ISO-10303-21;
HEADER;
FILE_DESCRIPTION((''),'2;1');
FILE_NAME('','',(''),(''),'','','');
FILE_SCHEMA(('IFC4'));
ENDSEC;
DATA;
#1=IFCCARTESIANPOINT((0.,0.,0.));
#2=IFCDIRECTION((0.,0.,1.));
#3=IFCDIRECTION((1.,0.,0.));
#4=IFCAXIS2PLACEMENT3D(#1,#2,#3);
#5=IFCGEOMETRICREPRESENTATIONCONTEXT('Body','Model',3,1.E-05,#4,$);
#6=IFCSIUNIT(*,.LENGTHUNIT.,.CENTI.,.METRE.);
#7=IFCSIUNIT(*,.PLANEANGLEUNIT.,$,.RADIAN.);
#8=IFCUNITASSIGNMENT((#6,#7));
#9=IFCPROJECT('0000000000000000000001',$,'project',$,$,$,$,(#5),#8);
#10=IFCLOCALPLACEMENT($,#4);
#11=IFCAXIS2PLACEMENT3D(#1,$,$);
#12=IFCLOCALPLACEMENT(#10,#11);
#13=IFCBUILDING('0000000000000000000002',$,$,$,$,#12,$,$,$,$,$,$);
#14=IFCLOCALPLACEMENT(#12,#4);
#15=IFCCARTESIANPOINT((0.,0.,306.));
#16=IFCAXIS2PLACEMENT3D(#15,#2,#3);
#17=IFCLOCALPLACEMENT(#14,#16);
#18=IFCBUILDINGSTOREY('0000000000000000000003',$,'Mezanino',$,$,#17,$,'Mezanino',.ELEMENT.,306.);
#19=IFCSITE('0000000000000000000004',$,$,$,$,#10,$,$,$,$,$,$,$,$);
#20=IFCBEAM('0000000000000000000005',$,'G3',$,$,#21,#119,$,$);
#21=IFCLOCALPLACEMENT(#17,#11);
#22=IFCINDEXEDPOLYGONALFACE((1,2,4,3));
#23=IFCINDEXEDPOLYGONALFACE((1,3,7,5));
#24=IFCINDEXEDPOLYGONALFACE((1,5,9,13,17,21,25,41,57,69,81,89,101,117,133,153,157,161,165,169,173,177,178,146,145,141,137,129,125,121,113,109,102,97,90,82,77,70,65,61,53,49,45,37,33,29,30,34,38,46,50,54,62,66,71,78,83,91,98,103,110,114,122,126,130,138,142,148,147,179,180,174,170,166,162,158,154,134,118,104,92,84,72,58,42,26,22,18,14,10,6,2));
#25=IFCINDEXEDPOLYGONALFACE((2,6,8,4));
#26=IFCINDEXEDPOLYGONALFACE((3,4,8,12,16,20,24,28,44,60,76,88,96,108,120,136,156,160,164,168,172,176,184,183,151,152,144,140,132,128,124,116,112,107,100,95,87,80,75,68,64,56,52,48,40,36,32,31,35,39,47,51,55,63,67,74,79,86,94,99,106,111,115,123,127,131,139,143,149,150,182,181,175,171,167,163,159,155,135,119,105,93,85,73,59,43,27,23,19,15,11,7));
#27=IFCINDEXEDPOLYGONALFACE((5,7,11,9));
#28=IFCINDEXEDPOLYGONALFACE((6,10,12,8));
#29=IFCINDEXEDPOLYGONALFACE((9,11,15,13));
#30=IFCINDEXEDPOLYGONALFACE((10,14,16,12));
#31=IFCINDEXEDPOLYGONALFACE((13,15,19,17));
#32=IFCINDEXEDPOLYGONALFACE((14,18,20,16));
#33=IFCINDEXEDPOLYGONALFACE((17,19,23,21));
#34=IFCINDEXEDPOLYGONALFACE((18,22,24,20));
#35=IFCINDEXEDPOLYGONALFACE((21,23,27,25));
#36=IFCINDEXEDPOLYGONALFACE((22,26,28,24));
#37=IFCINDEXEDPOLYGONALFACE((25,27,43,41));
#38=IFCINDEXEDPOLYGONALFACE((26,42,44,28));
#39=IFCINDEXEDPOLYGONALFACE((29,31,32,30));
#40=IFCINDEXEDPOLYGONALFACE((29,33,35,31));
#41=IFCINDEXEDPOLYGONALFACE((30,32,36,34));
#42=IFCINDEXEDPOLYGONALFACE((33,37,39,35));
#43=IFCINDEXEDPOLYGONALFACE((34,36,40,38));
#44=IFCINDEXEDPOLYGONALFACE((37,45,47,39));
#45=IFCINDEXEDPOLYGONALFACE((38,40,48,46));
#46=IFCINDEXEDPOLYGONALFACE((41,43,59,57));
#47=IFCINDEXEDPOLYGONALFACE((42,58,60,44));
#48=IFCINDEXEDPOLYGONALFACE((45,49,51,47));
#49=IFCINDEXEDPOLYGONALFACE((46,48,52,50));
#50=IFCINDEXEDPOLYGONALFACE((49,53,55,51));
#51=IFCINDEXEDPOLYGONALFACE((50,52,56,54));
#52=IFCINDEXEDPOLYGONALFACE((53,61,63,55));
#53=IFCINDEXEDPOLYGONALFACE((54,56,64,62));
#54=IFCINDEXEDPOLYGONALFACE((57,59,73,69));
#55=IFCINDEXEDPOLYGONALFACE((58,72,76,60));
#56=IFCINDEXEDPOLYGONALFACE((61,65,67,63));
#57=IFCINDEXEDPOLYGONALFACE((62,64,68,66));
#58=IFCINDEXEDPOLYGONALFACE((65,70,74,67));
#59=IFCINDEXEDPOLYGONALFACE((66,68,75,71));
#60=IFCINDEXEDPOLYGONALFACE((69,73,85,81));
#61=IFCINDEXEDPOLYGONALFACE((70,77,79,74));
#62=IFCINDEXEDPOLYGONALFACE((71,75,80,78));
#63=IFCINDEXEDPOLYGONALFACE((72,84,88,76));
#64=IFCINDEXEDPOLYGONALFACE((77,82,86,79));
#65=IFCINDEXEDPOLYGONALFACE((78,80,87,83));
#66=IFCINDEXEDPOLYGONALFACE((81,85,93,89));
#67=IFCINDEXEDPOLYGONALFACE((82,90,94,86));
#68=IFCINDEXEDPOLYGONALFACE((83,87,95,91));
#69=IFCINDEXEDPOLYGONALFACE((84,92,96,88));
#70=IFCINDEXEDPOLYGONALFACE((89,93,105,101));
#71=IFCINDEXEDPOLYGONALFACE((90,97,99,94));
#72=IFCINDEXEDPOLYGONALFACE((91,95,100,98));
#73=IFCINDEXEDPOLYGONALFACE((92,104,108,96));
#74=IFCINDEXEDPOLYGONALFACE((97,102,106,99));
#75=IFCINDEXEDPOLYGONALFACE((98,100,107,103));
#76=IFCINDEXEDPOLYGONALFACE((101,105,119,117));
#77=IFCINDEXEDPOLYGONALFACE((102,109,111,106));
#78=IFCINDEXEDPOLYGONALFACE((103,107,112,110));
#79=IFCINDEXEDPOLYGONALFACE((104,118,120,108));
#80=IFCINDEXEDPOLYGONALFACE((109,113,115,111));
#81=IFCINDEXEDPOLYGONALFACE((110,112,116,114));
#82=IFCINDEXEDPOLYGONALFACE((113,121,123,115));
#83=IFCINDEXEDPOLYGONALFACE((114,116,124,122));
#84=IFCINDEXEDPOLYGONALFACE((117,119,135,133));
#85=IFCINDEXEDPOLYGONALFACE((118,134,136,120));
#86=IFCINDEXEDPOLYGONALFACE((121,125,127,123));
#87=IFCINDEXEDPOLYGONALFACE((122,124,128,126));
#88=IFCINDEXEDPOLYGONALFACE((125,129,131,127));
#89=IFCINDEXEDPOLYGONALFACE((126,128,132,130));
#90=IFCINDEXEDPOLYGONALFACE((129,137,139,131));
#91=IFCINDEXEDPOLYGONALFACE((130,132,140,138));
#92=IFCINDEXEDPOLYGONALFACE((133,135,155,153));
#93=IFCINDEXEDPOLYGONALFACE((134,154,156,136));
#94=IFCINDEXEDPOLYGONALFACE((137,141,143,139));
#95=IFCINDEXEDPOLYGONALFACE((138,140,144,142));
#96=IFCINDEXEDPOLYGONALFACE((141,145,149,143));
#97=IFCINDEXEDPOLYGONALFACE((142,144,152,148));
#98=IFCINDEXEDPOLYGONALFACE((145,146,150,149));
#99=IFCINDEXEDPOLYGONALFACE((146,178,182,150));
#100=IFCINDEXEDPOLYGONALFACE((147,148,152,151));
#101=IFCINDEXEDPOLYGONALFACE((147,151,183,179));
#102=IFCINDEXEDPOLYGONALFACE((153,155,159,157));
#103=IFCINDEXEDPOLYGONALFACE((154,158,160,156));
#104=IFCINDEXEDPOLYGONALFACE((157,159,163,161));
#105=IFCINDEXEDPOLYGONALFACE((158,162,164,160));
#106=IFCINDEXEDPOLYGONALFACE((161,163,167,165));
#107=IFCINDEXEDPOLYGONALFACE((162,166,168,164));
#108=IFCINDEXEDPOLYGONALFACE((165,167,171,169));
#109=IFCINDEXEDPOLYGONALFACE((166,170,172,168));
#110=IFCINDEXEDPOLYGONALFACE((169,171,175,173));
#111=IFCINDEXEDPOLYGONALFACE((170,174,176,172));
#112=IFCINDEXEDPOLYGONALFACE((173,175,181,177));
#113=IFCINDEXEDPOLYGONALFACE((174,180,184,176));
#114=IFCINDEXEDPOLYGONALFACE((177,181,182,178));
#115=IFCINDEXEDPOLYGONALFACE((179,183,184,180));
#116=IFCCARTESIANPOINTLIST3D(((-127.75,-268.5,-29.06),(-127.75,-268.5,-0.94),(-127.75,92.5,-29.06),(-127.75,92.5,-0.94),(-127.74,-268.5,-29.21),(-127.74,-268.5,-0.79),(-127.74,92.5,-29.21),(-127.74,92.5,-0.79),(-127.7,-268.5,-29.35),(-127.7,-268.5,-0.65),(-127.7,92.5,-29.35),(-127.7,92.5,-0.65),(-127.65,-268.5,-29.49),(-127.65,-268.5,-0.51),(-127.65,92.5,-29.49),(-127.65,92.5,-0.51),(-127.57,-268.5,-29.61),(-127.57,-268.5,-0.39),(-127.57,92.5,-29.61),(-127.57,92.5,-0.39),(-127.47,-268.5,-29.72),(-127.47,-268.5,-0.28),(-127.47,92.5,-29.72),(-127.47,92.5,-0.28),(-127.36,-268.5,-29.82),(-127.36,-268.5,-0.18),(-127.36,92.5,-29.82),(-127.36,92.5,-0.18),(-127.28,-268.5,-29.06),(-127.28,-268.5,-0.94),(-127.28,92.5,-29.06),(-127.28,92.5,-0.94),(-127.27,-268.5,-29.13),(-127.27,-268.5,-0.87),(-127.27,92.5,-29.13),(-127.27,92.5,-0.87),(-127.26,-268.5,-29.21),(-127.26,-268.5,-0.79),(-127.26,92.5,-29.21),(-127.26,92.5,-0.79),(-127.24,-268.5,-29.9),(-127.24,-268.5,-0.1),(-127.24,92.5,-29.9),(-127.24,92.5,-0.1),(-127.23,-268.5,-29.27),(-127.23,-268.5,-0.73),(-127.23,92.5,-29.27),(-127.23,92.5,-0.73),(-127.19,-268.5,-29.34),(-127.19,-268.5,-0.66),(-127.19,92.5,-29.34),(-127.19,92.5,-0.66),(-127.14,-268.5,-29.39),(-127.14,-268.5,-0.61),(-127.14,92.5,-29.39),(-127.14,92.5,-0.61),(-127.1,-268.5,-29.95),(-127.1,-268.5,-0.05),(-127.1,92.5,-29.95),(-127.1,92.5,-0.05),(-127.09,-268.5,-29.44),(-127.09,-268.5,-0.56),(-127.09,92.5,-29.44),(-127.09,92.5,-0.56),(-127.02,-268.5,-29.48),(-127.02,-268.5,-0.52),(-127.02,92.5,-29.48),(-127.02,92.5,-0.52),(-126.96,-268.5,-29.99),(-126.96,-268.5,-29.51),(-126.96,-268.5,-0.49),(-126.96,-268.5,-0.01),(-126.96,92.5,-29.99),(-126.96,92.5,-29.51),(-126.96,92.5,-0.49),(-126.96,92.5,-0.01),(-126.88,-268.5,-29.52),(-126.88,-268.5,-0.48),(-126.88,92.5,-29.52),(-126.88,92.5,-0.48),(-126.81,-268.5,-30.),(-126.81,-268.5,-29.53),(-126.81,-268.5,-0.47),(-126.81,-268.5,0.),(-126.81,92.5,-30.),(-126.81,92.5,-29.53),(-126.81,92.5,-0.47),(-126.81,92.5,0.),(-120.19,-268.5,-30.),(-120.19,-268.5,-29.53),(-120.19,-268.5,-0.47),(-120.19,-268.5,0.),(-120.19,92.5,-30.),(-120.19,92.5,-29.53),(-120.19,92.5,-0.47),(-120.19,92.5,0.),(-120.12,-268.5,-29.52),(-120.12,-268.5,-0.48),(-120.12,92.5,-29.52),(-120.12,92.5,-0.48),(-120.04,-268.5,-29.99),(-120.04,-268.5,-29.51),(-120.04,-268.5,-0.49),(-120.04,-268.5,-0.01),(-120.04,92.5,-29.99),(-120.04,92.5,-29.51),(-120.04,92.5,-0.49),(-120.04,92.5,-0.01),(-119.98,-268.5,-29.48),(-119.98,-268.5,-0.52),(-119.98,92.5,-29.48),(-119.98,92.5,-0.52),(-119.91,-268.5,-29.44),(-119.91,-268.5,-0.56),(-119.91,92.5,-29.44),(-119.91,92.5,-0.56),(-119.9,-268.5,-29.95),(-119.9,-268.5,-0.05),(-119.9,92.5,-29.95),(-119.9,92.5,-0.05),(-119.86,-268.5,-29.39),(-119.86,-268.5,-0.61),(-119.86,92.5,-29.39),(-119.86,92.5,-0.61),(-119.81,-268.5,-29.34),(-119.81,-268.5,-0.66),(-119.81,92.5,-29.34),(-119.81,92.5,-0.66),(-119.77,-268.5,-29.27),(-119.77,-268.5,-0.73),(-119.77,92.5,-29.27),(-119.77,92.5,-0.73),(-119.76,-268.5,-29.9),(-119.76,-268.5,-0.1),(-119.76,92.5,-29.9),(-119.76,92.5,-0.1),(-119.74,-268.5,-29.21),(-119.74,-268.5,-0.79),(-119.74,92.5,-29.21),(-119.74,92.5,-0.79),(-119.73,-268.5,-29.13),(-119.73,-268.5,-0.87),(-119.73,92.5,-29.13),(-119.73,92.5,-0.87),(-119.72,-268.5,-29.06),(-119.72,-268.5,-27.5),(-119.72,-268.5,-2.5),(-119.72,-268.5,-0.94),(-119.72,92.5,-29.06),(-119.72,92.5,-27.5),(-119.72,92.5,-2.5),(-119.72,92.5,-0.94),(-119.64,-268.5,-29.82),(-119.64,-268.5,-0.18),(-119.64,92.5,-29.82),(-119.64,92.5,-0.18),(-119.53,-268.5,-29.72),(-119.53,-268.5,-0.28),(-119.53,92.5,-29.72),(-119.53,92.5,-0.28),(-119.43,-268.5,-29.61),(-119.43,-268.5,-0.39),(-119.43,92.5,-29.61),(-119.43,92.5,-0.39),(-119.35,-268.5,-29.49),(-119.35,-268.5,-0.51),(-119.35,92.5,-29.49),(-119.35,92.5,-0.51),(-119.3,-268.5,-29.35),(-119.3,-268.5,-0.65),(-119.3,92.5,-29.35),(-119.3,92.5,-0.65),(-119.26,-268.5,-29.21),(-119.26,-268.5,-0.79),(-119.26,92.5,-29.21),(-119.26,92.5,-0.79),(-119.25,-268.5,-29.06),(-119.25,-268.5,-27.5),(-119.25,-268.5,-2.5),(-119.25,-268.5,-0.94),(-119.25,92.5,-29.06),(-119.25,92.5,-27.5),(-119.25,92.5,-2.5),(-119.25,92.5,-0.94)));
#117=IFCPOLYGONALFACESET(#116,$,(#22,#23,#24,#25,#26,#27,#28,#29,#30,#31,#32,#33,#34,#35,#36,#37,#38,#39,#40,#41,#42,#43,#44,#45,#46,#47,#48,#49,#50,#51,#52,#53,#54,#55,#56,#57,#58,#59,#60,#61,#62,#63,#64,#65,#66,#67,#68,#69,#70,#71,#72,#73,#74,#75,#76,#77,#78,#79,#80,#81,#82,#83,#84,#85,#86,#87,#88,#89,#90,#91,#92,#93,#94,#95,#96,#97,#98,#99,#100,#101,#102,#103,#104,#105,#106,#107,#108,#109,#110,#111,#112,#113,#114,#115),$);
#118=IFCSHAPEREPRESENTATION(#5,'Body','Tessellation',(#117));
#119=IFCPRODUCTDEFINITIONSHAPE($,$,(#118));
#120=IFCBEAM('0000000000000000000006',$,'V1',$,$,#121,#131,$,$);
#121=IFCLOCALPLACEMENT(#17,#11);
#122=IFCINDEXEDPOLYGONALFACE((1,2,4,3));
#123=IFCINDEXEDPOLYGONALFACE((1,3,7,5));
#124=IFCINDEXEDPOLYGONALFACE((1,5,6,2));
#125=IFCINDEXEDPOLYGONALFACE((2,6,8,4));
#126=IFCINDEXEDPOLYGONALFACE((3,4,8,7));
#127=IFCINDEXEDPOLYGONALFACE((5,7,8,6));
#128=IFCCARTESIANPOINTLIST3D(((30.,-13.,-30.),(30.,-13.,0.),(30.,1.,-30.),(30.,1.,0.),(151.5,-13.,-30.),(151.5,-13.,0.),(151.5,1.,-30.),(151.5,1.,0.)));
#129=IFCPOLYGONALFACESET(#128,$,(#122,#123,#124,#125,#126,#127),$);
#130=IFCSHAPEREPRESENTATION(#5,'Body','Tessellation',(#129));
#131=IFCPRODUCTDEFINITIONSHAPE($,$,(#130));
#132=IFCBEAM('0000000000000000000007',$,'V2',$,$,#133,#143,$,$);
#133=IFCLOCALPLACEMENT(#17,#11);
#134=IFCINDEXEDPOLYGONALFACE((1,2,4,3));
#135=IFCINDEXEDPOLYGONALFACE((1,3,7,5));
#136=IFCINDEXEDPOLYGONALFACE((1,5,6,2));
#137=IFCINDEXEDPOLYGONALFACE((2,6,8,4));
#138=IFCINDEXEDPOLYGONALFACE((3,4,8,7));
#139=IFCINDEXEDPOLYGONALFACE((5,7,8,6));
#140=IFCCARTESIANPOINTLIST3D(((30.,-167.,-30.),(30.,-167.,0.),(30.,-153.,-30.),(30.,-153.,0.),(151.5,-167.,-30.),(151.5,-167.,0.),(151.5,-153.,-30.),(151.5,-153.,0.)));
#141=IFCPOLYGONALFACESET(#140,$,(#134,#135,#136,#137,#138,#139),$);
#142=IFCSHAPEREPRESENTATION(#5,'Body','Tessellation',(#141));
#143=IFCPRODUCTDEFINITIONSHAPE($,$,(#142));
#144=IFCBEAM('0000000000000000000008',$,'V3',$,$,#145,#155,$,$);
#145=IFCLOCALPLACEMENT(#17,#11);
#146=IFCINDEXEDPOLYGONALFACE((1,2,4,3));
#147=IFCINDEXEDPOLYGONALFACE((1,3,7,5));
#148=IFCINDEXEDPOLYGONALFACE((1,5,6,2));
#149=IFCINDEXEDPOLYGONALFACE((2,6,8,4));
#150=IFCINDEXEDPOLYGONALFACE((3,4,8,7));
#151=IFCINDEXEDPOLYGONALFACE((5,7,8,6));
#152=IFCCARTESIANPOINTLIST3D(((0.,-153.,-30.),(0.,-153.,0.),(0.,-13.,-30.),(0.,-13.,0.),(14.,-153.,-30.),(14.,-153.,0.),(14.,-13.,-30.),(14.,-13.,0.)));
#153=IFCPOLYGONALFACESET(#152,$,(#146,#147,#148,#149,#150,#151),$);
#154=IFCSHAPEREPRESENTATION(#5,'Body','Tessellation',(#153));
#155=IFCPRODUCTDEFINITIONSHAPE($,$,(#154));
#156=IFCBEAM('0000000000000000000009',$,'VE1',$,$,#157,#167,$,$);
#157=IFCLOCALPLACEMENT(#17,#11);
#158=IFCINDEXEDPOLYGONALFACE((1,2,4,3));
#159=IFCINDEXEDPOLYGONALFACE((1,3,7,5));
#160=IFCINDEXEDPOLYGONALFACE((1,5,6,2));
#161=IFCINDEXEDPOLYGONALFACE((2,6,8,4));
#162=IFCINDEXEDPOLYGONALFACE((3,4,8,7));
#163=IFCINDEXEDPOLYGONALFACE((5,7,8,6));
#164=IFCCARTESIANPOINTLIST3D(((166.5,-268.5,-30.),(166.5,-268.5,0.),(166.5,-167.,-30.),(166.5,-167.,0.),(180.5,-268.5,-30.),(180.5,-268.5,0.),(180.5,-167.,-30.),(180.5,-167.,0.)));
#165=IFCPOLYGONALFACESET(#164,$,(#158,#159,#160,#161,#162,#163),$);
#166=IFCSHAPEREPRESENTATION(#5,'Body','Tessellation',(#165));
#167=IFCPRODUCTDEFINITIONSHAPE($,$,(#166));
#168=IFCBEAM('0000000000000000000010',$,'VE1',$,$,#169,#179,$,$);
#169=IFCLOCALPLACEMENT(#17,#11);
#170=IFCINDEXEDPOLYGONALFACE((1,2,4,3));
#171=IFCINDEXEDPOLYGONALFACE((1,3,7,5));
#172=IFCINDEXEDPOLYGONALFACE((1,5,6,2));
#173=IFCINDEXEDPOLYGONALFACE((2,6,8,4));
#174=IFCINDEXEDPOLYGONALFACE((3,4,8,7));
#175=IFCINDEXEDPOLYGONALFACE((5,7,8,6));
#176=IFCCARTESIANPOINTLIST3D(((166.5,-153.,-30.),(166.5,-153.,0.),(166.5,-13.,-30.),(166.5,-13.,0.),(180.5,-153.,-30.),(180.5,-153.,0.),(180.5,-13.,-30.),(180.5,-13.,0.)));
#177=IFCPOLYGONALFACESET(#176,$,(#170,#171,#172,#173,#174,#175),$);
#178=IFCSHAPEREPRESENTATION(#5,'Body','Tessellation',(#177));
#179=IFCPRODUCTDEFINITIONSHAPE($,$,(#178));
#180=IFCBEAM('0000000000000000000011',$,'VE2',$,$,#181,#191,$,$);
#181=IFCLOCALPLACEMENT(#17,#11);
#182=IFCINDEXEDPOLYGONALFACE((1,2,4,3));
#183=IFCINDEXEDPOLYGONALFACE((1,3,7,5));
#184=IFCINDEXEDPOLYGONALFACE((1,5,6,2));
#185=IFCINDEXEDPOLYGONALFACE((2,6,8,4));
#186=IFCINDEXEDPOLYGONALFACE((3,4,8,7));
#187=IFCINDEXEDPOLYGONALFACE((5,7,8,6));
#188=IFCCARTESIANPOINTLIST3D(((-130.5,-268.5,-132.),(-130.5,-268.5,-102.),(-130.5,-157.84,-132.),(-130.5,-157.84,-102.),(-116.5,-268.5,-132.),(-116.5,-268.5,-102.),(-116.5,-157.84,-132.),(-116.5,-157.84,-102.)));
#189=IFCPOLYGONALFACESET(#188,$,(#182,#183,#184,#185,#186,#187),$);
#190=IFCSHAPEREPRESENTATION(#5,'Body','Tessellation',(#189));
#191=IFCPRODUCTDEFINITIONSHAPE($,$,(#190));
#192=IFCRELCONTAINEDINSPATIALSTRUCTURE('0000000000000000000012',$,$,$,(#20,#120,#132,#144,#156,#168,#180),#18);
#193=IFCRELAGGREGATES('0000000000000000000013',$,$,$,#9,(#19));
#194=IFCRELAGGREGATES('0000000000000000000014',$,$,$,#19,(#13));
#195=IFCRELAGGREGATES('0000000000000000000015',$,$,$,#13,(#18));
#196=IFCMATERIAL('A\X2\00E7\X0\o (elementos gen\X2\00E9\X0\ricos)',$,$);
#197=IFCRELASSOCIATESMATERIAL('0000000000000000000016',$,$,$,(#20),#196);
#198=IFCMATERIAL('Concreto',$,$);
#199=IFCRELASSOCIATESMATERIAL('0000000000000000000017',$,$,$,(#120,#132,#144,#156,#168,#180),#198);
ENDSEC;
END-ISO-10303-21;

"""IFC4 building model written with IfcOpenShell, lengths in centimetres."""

from ifc_helpers import new_model, si_unit, frame, origin, origin_with_axes, origin_2d_with_axis, place, context, project, spatial, polyline, rectangle, outline, extrude, material, element, save


model = new_model("IFC4")

# Units and contexts
model_context = context("Model", 3, precision=1e-05, world=origin_with_axes(), identifier="Body")
ifc_project = project(units=[si_unit("LENGTHUNIT", "METRE", prefix="CENTI"), si_unit("PLANEANGLEUNIT", "RADIAN")], contexts=[model_context])

# Site, building, storey
site_placement = place(None, origin_with_axes())
site = spatial("IfcSite", under=ifc_project, at=site_placement)
building_placement = place(site_placement, origin())
building = spatial("IfcBuilding", under=site, at=building_placement)
placement = place(building_placement, origin_with_axes())
storey_placement = place(placement, frame((0.0, 0.0, 306.0), z_axis=(0.0, 0.0, 1.0), x_axis=(1.0, 0.0, 0.0)))
storey = spatial("IfcBuildingStorey", under=building, at=storey_placement, Name="Mezanino", LongName="Mezanino", CompositionType="ELEMENT", Elevation=306.0)

# Shared definitions
ifc_material_1 = material(Name="Concreto")

# Beams
ifc_material_2 = material(Name="Aço (elementos genéricos)")
beam_1_placement = place(storey_placement, frame((-123.5, -88.0, 0.0), z_axis=(0.0, 0.0, 1.0), x_axis=(1.0, 0.0, 0.0)))
element("IfcBeam", 1, at=beam_1_placement, inside=storey, material=ifc_material_2, Name="G3", context=model_context, shape_type="SolidModel", body=[
    extrude(outline(polyline([(-4.25, -14.06), (-4.24, -14.21), (-4.2, -14.35), (-4.15, -14.49), (-4.07, -14.61), (-3.97, -14.72), (-3.86, -14.82), (-3.74, -14.9), (-3.6, -14.95), (-3.46, -14.99), (-3.31, -15.0), (3.31, -15.0), (3.46, -14.99), (3.6, -14.95), (3.74, -14.9), (3.86, -14.82), (3.97, -14.72), (4.07, -14.61), (4.15, -14.49), (4.2, -14.35), (4.24, -14.21), (4.25, -14.06), (4.25, -12.5), (3.78, -12.5), (3.78, -14.06), (3.77, -14.13), (3.76, -14.21), (3.73, -14.27), (3.69, -14.34), (3.64, -14.39), (3.59, -14.44), (3.52, -14.48), (3.46, -14.51), (3.38, -14.52), (3.31, -14.53), (-3.31, -14.53), (-3.38, -14.52), (-3.46, -14.51), (-3.52, -14.48), (-3.59, -14.44), (-3.64, -14.39), (-3.69, -14.34), (-3.73, -14.27), (-3.76, -14.21), (-3.77, -14.13), (-3.78, -14.06), (-3.78, 14.06), (-3.77, 14.13), (-3.76, 14.21), (-3.73, 14.27), (-3.69, 14.34), (-3.64, 14.39), (-3.59, 14.44), (-3.52, 14.48), (-3.46, 14.51), (-3.38, 14.52), (-3.31, 14.53), (3.31, 14.53), (3.38, 14.52), (3.46, 14.51), (3.52, 14.48), (3.59, 14.44), (3.64, 14.39), (3.69, 14.34), (3.73, 14.27), (3.76, 14.21), (3.77, 14.13), (3.78, 14.06), (3.78, 12.5), (4.25, 12.5), (4.25, 14.06), (4.24, 14.21), (4.2, 14.35), (4.15, 14.49), (4.07, 14.61), (3.97, 14.72), (3.86, 14.82), (3.74, 14.9), (3.6, 14.95), (3.46, 14.99), (3.31, 15.0), (-3.31, 15.0), (-3.46, 14.99), (-3.6, 14.95), (-3.74, 14.9), (-3.86, 14.82), (-3.97, 14.72), (-4.07, 14.61), (-4.15, 14.49), (-4.2, 14.35), (-4.24, 14.21), (-4.25, 14.06), (-4.25, -14.06)])), frame((0.0, -180.5, -15.0), z_axis=(0.0, 1.0, 0.0), x_axis=(1.0, 0.0, 0.0)), (0.0, 0.0, 1.0), 361.0),
])
beam_2_placement = place(storey_placement, frame((90.75, -6.0, 0.0), z_axis=(0.0, 0.0, 1.0), x_axis=(1.0, 0.0, 0.0)))
element("IfcBeam", 2, at=beam_2_placement, inside=storey, material=ifc_material_1, Name="V1", context=model_context, shape_type="SolidModel", body=[
    extrude(rectangle(XDim=14.0, YDim=30.0, at=origin_2d_with_axis()), frame((-60.75, 0.0, -15.0), z_axis=(1.0, 0.0, 0.0), x_axis=(0.0, 1.0, 0.0)), (0.0, 0.0, 1.0), 121.5),
])
beam_3_placement = place(storey_placement, frame((90.75, -160.0, 0.0), z_axis=(0.0, 0.0, 1.0), x_axis=(1.0, 0.0, 0.0)))
element("IfcBeam", 3, at=beam_3_placement, inside=storey, material=ifc_material_1, Name="V2", context=model_context, shape_type="SolidModel", body=[
    extrude(rectangle(XDim=14.0, YDim=30.0, at=origin_2d_with_axis()), frame((-60.75, 0.0, -15.0), z_axis=(1.0, 0.0, 0.0), x_axis=(0.0, -1.0, 0.0)), (0.0, 0.0, 1.0), 121.5),
])
beam_4_placement = place(storey_placement, frame((7.0, -83.0, 0.0), z_axis=(0.0, 0.0, 1.0), x_axis=(1.0, 0.0, 0.0)))
element("IfcBeam", 4, at=beam_4_placement, inside=storey, material=ifc_material_1, Name="V3", context=model_context, shape_type="SolidModel", body=[
    extrude(rectangle(XDim=14.0, YDim=30.0, at=origin_2d_with_axis()), frame((0.0, -70.0, -15.0), z_axis=(0.0, 1.0, 0.0), x_axis=(1.0, 0.0, 0.0)), (0.0, 0.0, 1.0), 140.0),
])
beam_5_placement = place(storey_placement, frame((173.5, -217.75, 0.0), z_axis=(0.0, 0.0, 1.0), x_axis=(1.0, 0.0, 0.0)))
element("IfcBeam", 5, at=beam_5_placement, inside=storey, material=ifc_material_1, Name="VE1", context=model_context, shape_type="SolidModel", body=[
    extrude(rectangle(XDim=14.0, YDim=30.0, at=origin_2d_with_axis()), frame((0.0, -50.75, -15.0), z_axis=(0.0, 1.0, 0.0), x_axis=(1.0, 0.0, 0.0)), (0.0, 0.0, 1.0), 101.5),
])
beam_6_placement = place(storey_placement, frame((173.5, -83.0, 0.0), z_axis=(0.0, 0.0, 1.0), x_axis=(1.0, 0.0, 0.0)))
element("IfcBeam", 6, at=beam_6_placement, inside=storey, material=ifc_material_1, Name="VE1", context=model_context, shape_type="SolidModel", body=[
    extrude(rectangle(XDim=14.0, YDim=30.0, at=origin_2d_with_axis()), frame((0.0, -70.0, -15.0), z_axis=(0.0, 1.0, 0.0), x_axis=(1.0, 0.0, 0.0)), (0.0, 0.0, 1.0), 140.0),
])
beam_7_placement = place(storey_placement, frame((-123.5, -213.17, -102.0), z_axis=(0.0, 0.0, 1.0), x_axis=(1.0, 0.0, 0.0)))
element("IfcBeam", 7, at=beam_7_placement, inside=storey, material=ifc_material_1, Name="VE2", context=model_context, shape_type="SolidModel", body=[
    extrude(rectangle(XDim=14.0, YDim=30.0, at=origin_2d_with_axis()), frame((0.0, -55.33, -15.0), z_axis=(0.0, 1.0, 0.0), x_axis=(1.0, 0.0, 0.0)), (0.0, 0.0, 1.0), 110.66),
])

save(model, "model.ifc")
